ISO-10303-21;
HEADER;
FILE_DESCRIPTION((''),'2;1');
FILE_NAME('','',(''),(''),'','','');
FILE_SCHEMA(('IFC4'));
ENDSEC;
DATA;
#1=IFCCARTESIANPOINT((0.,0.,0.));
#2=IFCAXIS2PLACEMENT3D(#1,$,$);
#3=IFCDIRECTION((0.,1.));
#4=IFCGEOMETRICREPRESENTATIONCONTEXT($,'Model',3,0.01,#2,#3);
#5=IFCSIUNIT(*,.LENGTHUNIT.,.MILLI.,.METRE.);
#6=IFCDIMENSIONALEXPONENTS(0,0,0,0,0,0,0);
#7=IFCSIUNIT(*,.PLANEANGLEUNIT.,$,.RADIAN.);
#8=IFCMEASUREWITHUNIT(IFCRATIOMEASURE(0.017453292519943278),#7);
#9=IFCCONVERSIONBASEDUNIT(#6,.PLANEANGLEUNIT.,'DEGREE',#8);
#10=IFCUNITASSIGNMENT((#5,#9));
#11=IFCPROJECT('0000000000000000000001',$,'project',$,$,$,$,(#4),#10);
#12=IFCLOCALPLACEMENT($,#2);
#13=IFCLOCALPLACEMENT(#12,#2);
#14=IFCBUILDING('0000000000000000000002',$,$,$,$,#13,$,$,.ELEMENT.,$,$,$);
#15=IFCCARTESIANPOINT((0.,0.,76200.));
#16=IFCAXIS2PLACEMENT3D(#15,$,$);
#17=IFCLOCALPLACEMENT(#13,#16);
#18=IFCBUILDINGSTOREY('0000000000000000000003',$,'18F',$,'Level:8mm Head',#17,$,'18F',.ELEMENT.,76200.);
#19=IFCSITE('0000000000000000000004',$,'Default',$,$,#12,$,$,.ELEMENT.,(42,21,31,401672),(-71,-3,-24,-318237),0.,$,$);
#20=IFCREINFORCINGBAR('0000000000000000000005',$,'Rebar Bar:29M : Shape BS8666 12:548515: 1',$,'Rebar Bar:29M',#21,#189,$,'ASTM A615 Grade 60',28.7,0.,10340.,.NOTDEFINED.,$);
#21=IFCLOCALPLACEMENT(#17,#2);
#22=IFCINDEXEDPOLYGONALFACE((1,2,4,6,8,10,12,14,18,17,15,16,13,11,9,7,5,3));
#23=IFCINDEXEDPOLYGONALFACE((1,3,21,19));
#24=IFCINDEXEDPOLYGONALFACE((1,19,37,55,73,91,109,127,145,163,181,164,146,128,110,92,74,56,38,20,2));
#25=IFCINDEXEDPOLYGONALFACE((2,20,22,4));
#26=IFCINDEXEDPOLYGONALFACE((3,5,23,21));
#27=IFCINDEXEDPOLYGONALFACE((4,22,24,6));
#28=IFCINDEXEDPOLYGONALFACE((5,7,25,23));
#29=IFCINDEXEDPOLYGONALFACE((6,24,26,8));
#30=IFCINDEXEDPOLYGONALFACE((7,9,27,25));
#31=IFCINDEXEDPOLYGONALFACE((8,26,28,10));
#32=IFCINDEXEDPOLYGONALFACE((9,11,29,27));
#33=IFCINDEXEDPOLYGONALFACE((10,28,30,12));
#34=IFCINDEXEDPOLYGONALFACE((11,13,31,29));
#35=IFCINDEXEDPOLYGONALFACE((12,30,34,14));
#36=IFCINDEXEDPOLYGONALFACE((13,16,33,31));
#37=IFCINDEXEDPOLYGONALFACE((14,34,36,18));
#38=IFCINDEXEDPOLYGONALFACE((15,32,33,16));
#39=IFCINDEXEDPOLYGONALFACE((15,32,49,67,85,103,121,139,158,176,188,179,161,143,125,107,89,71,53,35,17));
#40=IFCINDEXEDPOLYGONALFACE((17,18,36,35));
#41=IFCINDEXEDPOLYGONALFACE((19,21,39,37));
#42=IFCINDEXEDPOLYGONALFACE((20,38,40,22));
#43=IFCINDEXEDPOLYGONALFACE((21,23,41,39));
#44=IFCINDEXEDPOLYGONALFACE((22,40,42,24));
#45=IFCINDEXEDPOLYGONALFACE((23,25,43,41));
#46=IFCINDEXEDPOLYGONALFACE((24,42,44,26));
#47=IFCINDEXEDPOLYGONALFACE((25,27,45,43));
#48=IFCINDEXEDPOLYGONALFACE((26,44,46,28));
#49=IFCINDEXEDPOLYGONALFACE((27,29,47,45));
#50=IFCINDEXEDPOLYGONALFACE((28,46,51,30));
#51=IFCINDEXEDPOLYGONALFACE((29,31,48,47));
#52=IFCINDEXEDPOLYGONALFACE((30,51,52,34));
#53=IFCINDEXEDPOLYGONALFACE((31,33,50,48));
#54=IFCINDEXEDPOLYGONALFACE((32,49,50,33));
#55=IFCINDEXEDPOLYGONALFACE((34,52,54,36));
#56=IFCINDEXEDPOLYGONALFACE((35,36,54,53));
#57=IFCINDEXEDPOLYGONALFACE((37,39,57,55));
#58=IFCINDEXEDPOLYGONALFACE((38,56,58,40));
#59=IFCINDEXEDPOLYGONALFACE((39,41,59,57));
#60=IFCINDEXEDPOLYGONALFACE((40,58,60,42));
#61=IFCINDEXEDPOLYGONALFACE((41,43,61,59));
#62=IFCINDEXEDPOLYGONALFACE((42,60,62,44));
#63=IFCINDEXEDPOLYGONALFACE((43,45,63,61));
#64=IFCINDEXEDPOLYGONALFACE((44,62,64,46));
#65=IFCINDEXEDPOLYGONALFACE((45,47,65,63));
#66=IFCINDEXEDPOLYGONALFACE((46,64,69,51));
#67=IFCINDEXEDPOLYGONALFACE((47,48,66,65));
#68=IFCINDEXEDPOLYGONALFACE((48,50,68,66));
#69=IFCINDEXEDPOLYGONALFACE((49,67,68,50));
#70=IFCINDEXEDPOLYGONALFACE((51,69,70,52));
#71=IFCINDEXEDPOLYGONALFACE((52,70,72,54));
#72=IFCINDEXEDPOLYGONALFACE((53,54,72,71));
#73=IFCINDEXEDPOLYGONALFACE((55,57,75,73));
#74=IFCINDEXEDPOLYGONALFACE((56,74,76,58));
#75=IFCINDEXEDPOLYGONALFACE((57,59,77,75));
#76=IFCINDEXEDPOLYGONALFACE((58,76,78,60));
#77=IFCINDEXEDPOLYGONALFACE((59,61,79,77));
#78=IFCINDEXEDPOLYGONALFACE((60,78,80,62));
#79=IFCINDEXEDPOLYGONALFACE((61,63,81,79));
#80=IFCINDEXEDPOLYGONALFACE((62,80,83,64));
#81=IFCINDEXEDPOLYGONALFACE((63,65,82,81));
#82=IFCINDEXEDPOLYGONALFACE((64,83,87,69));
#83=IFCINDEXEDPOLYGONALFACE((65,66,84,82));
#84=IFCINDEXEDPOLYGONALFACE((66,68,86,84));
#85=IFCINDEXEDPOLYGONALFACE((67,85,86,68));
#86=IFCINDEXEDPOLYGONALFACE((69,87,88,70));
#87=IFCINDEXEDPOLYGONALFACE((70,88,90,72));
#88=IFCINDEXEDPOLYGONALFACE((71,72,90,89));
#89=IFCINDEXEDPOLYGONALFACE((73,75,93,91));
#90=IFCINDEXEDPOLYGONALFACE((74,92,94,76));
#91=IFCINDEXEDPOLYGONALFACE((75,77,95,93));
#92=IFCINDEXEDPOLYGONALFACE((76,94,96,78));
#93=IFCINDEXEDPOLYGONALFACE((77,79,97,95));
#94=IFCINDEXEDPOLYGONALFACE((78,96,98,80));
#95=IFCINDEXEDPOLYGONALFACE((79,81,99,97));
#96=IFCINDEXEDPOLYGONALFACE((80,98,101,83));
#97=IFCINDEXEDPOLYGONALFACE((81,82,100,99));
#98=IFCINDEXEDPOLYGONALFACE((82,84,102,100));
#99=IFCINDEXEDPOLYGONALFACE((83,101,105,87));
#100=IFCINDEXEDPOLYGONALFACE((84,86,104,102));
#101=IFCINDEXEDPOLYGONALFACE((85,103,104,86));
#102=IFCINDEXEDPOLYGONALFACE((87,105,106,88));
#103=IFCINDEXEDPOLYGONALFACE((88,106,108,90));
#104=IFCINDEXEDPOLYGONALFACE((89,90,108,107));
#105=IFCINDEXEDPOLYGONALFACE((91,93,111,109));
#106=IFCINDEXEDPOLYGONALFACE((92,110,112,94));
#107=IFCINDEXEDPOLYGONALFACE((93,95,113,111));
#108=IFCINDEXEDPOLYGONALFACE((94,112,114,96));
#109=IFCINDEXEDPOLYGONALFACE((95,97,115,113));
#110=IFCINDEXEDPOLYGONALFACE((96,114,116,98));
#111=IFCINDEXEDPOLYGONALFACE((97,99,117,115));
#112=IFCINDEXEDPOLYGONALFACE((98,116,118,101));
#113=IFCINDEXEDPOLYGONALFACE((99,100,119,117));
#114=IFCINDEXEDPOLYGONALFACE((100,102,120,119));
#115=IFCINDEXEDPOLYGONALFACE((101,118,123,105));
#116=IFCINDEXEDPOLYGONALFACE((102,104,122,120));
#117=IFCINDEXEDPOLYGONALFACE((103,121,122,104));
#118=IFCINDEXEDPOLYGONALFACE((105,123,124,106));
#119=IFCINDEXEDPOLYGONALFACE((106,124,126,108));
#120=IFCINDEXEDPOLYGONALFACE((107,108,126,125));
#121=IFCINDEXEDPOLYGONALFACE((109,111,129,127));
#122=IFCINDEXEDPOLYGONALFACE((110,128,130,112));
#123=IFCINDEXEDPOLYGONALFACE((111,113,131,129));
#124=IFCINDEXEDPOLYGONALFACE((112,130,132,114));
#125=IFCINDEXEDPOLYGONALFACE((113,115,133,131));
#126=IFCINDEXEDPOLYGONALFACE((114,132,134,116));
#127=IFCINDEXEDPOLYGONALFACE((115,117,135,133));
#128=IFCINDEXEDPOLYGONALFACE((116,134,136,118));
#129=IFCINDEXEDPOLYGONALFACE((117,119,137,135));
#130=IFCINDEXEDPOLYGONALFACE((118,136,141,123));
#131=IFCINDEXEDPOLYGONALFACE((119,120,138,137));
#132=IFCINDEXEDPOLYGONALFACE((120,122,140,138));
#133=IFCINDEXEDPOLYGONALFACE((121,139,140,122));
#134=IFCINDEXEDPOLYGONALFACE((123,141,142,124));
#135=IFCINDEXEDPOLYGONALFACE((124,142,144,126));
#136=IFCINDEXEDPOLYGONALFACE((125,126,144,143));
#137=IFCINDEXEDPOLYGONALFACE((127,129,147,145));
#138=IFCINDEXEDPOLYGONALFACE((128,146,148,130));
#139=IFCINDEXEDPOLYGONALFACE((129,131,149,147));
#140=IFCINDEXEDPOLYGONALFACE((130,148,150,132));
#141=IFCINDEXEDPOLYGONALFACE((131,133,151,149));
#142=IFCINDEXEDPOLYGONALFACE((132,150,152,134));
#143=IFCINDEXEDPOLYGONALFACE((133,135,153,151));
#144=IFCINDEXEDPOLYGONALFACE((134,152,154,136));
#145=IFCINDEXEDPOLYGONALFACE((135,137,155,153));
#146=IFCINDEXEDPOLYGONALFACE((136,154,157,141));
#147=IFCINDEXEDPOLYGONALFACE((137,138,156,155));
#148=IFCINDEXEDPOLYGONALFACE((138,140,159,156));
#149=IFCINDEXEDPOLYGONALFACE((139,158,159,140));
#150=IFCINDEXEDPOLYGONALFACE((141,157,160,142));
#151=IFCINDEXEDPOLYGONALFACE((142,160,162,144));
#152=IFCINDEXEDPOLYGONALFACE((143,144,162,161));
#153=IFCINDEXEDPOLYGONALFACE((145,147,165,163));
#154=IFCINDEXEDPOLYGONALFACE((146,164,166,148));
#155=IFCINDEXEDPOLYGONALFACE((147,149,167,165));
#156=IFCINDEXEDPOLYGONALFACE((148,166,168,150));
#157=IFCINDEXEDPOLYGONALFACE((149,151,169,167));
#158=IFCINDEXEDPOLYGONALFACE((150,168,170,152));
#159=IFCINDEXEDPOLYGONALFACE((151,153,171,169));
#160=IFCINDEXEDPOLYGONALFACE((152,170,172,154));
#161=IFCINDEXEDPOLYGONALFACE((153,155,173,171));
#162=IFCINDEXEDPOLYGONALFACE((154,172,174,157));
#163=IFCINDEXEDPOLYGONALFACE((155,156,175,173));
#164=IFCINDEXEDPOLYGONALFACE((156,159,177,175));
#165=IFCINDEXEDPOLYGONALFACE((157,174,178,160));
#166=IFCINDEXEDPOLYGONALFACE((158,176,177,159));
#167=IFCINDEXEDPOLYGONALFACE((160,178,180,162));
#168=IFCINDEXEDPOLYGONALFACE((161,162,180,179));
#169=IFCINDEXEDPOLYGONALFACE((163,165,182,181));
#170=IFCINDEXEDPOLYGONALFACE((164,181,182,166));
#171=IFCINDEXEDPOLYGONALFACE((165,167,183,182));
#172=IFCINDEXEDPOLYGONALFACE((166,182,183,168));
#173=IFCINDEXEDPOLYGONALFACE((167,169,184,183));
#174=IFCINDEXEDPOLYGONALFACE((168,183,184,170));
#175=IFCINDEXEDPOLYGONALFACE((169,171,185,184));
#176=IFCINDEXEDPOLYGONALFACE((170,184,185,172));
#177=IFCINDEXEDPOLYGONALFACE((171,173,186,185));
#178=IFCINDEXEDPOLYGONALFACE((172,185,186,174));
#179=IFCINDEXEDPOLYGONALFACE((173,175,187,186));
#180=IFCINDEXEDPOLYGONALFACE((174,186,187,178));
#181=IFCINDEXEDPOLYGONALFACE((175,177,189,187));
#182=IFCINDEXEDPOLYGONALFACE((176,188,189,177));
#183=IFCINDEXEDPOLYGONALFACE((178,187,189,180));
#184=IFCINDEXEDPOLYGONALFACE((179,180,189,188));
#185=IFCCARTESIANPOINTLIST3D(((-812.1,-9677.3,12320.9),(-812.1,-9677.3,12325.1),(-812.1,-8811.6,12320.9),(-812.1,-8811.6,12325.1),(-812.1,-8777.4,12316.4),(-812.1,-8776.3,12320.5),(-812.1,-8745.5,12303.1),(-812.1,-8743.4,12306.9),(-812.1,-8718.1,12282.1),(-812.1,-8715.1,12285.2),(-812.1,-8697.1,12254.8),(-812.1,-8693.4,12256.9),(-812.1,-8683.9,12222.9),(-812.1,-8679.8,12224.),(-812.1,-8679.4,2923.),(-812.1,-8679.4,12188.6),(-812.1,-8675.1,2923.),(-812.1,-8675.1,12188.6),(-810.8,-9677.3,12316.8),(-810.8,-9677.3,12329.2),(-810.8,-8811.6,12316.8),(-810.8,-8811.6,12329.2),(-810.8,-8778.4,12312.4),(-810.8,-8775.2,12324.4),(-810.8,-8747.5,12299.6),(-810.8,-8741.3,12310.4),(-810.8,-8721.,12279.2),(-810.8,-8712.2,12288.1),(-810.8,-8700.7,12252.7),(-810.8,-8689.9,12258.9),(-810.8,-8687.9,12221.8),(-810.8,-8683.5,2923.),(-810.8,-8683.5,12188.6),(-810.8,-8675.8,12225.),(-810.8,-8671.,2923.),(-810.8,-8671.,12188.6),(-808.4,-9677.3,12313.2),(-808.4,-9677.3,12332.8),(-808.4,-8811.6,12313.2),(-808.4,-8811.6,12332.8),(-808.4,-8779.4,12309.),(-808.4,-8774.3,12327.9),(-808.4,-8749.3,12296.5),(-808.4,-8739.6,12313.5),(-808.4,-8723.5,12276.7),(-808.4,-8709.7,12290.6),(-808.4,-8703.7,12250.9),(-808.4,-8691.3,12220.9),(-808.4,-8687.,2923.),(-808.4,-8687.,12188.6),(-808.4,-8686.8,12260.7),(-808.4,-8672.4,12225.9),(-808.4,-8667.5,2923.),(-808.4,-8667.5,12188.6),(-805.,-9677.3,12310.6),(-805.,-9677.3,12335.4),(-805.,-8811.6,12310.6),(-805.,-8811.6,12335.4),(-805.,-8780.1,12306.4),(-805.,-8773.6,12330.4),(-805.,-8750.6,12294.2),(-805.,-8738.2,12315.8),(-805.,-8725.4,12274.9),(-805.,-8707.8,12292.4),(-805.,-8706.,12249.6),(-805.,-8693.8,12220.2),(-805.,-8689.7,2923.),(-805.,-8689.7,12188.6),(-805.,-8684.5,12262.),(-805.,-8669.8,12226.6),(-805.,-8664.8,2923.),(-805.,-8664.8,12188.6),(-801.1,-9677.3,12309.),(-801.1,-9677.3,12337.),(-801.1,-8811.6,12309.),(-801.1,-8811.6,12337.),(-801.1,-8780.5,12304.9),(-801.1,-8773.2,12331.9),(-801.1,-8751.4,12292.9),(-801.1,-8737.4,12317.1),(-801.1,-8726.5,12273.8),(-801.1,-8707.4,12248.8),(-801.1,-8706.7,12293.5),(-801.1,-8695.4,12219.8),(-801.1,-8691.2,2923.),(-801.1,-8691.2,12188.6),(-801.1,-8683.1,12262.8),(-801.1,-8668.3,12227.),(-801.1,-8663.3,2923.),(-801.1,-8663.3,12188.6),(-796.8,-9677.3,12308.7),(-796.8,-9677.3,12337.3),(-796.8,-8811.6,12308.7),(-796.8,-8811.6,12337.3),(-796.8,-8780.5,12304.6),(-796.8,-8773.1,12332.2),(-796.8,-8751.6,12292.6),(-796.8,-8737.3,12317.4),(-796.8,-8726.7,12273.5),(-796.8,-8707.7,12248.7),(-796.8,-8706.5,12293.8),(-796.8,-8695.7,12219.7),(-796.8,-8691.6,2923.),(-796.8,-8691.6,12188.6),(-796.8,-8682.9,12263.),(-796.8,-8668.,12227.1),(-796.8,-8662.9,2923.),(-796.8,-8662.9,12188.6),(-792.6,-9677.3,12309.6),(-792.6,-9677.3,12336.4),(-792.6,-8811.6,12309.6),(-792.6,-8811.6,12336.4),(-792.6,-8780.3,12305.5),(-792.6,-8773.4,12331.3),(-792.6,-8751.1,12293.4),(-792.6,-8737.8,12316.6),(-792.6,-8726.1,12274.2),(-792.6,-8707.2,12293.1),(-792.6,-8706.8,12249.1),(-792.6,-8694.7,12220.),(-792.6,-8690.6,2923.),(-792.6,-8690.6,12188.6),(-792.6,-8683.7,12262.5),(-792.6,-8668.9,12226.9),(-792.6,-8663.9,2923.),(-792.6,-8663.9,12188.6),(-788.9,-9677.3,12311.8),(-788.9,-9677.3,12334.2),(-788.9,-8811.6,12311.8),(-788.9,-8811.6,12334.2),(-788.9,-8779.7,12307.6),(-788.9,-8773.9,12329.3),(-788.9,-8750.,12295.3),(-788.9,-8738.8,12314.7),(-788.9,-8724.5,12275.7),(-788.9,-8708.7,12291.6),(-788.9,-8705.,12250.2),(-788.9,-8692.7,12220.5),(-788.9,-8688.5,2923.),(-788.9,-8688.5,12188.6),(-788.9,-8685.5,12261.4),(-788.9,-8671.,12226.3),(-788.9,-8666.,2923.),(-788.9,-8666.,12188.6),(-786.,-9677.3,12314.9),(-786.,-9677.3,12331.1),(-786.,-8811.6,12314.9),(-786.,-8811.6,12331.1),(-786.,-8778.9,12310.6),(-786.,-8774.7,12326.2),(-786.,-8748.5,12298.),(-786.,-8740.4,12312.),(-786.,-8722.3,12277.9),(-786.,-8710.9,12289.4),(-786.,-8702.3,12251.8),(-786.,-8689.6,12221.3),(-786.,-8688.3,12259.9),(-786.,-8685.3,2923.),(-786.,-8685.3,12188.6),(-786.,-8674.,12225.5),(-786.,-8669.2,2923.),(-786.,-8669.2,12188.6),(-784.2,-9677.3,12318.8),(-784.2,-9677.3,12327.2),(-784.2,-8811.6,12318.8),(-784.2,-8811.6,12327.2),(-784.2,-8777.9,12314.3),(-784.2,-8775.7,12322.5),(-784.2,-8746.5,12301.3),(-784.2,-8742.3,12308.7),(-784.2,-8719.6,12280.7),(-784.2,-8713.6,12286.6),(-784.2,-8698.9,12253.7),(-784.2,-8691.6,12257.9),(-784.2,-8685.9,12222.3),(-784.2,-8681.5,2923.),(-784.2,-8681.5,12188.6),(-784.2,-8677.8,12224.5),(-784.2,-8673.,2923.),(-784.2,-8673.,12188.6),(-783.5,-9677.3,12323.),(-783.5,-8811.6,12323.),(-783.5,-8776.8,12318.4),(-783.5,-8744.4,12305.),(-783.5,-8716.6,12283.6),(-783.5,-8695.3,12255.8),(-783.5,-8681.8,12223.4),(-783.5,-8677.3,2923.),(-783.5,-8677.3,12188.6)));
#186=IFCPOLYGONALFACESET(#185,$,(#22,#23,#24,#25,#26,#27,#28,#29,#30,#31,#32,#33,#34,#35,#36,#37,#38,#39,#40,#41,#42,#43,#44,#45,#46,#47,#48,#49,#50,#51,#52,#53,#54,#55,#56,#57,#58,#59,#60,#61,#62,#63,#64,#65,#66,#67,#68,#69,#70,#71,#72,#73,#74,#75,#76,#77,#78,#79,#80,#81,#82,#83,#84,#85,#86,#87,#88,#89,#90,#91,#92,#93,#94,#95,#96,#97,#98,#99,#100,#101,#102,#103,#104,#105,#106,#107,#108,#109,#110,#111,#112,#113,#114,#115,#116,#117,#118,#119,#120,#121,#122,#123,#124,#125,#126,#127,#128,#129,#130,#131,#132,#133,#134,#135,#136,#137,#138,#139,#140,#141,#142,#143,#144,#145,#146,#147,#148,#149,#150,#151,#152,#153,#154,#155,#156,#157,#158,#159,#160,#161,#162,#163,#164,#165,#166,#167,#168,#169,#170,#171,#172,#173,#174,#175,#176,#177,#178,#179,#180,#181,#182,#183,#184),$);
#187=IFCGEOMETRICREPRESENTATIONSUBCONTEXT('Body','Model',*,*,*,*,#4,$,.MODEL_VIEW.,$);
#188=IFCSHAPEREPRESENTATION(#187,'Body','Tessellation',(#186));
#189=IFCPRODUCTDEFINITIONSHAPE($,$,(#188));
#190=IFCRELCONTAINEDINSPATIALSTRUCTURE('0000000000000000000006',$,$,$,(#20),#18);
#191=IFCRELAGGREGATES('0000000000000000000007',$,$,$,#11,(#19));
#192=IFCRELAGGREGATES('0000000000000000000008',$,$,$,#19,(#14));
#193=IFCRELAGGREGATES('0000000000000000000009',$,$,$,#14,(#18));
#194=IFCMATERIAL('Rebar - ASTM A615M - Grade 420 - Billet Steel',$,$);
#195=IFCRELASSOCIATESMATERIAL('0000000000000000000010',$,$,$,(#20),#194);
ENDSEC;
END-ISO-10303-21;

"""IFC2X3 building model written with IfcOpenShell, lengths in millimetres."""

from ifc_helpers import new_model, entity, si_unit, converted_unit, direction, frame, origin, place, context, subcontext, project, spatial, material, element, save


model = new_model("IFC2X3")

# Units and contexts
model_context = context("Model", 3, precision=0.01, world=origin(), true_north=direction((0.0, 1.0)))
body_context = subcontext(model_context, "Body", "Model", "MODEL_VIEW")
ifc_project = project(units=[si_unit("LENGTHUNIT", "METRE", prefix="MILLI"), converted_unit("PLANEANGLEUNIT", "DEGREE", entity("IfcRatioMeasure", 0.017453292519943278), si_unit("PLANEANGLEUNIT", "RADIAN"), dimensions=[0, 0, 0, 0, 0, 0, 0])], contexts=[model_context])

# Site, building, storey
site_placement = place(None, origin())
site = spatial("IfcSite", under=ifc_project, at=site_placement, Name="Default", CompositionType="ELEMENT", RefLatitude=(42, 21, 31, 401672), RefLongitude=(-71, -3, -24, -318237), RefElevation=0.0)
building_placement = place(site_placement, origin())
building = spatial("IfcBuilding", under=site, at=building_placement, CompositionType="ELEMENT")
storey_placement = place(building_placement, frame((0.0, 0.0, 76200.0)))
storey = spatial("IfcBuildingStorey", under=building, at=storey_placement, Name="18F", ObjectType="Level:8mm Head", LongName="18F", CompositionType="ELEMENT", Elevation=76200.0)

# Reinforcing bar
ifc_material_1 = material(Name="Rebar - ASTM A615M - Grade 420 - Billet Steel")
reinforcing_bar_1_placement = place(storey_placement, origin())
element("IfcReinforcingBar", 1, at=reinforcing_bar_1_placement, inside=storey, material=ifc_material_1, Name="Rebar Bar:29M : Shape BS8666 12:548515: 1", SteelGrade="ASTM A615 Grade 60", ObjectType="Rebar Bar:29M", BarLength=10340.0, BarRole="NOTDEFINED", CrossSectionArea=0.0, NominalDiameter=28.7, context=body_context, shape_type="AdvancedSweptSolid", body=[
    entity("IfcSweptDiskSolid", entity("IfcCompositeCurve", [entity("IfcCompositeCurveSegment", "CONTINUOUS", True, entity("IfcPolyline", [entity("IfcCartesianPoint", [-797.9, -8677.3, 2923.0]), entity("IfcCartesianPoint", [-797.9, -8677.3, 12188.6])])), entity("IfcCompositeCurveSegment", "CONTINUOUS", True, entity("IfcTrimmedCurve", entity("IfcCircle", entity("IfcAxis2Placement3D", entity("IfcCartesianPoint", [-797.9, -8811.6, 12188.6]), entity("IfcDirection", [1.0, 0.0, 0.0]), entity("IfcDirection", [0.0, 0.0, 1.0])), 134.3), [entity("IfcParameterValue", 270.0)], [entity("IfcParameterValue", 360.0)], True, "PARAMETER")), entity("IfcCompositeCurveSegment", "CONTINUOUS", True, entity("IfcPolyline", [entity("IfcCartesianPoint", [-797.9, -8811.6, 12323.0]), entity("IfcCartesianPoint", [-797.9, -9677.3, 12323.0])]))], False), 14.3, None, 0.0, 92.0),
])

save(model, "model.ifc")
